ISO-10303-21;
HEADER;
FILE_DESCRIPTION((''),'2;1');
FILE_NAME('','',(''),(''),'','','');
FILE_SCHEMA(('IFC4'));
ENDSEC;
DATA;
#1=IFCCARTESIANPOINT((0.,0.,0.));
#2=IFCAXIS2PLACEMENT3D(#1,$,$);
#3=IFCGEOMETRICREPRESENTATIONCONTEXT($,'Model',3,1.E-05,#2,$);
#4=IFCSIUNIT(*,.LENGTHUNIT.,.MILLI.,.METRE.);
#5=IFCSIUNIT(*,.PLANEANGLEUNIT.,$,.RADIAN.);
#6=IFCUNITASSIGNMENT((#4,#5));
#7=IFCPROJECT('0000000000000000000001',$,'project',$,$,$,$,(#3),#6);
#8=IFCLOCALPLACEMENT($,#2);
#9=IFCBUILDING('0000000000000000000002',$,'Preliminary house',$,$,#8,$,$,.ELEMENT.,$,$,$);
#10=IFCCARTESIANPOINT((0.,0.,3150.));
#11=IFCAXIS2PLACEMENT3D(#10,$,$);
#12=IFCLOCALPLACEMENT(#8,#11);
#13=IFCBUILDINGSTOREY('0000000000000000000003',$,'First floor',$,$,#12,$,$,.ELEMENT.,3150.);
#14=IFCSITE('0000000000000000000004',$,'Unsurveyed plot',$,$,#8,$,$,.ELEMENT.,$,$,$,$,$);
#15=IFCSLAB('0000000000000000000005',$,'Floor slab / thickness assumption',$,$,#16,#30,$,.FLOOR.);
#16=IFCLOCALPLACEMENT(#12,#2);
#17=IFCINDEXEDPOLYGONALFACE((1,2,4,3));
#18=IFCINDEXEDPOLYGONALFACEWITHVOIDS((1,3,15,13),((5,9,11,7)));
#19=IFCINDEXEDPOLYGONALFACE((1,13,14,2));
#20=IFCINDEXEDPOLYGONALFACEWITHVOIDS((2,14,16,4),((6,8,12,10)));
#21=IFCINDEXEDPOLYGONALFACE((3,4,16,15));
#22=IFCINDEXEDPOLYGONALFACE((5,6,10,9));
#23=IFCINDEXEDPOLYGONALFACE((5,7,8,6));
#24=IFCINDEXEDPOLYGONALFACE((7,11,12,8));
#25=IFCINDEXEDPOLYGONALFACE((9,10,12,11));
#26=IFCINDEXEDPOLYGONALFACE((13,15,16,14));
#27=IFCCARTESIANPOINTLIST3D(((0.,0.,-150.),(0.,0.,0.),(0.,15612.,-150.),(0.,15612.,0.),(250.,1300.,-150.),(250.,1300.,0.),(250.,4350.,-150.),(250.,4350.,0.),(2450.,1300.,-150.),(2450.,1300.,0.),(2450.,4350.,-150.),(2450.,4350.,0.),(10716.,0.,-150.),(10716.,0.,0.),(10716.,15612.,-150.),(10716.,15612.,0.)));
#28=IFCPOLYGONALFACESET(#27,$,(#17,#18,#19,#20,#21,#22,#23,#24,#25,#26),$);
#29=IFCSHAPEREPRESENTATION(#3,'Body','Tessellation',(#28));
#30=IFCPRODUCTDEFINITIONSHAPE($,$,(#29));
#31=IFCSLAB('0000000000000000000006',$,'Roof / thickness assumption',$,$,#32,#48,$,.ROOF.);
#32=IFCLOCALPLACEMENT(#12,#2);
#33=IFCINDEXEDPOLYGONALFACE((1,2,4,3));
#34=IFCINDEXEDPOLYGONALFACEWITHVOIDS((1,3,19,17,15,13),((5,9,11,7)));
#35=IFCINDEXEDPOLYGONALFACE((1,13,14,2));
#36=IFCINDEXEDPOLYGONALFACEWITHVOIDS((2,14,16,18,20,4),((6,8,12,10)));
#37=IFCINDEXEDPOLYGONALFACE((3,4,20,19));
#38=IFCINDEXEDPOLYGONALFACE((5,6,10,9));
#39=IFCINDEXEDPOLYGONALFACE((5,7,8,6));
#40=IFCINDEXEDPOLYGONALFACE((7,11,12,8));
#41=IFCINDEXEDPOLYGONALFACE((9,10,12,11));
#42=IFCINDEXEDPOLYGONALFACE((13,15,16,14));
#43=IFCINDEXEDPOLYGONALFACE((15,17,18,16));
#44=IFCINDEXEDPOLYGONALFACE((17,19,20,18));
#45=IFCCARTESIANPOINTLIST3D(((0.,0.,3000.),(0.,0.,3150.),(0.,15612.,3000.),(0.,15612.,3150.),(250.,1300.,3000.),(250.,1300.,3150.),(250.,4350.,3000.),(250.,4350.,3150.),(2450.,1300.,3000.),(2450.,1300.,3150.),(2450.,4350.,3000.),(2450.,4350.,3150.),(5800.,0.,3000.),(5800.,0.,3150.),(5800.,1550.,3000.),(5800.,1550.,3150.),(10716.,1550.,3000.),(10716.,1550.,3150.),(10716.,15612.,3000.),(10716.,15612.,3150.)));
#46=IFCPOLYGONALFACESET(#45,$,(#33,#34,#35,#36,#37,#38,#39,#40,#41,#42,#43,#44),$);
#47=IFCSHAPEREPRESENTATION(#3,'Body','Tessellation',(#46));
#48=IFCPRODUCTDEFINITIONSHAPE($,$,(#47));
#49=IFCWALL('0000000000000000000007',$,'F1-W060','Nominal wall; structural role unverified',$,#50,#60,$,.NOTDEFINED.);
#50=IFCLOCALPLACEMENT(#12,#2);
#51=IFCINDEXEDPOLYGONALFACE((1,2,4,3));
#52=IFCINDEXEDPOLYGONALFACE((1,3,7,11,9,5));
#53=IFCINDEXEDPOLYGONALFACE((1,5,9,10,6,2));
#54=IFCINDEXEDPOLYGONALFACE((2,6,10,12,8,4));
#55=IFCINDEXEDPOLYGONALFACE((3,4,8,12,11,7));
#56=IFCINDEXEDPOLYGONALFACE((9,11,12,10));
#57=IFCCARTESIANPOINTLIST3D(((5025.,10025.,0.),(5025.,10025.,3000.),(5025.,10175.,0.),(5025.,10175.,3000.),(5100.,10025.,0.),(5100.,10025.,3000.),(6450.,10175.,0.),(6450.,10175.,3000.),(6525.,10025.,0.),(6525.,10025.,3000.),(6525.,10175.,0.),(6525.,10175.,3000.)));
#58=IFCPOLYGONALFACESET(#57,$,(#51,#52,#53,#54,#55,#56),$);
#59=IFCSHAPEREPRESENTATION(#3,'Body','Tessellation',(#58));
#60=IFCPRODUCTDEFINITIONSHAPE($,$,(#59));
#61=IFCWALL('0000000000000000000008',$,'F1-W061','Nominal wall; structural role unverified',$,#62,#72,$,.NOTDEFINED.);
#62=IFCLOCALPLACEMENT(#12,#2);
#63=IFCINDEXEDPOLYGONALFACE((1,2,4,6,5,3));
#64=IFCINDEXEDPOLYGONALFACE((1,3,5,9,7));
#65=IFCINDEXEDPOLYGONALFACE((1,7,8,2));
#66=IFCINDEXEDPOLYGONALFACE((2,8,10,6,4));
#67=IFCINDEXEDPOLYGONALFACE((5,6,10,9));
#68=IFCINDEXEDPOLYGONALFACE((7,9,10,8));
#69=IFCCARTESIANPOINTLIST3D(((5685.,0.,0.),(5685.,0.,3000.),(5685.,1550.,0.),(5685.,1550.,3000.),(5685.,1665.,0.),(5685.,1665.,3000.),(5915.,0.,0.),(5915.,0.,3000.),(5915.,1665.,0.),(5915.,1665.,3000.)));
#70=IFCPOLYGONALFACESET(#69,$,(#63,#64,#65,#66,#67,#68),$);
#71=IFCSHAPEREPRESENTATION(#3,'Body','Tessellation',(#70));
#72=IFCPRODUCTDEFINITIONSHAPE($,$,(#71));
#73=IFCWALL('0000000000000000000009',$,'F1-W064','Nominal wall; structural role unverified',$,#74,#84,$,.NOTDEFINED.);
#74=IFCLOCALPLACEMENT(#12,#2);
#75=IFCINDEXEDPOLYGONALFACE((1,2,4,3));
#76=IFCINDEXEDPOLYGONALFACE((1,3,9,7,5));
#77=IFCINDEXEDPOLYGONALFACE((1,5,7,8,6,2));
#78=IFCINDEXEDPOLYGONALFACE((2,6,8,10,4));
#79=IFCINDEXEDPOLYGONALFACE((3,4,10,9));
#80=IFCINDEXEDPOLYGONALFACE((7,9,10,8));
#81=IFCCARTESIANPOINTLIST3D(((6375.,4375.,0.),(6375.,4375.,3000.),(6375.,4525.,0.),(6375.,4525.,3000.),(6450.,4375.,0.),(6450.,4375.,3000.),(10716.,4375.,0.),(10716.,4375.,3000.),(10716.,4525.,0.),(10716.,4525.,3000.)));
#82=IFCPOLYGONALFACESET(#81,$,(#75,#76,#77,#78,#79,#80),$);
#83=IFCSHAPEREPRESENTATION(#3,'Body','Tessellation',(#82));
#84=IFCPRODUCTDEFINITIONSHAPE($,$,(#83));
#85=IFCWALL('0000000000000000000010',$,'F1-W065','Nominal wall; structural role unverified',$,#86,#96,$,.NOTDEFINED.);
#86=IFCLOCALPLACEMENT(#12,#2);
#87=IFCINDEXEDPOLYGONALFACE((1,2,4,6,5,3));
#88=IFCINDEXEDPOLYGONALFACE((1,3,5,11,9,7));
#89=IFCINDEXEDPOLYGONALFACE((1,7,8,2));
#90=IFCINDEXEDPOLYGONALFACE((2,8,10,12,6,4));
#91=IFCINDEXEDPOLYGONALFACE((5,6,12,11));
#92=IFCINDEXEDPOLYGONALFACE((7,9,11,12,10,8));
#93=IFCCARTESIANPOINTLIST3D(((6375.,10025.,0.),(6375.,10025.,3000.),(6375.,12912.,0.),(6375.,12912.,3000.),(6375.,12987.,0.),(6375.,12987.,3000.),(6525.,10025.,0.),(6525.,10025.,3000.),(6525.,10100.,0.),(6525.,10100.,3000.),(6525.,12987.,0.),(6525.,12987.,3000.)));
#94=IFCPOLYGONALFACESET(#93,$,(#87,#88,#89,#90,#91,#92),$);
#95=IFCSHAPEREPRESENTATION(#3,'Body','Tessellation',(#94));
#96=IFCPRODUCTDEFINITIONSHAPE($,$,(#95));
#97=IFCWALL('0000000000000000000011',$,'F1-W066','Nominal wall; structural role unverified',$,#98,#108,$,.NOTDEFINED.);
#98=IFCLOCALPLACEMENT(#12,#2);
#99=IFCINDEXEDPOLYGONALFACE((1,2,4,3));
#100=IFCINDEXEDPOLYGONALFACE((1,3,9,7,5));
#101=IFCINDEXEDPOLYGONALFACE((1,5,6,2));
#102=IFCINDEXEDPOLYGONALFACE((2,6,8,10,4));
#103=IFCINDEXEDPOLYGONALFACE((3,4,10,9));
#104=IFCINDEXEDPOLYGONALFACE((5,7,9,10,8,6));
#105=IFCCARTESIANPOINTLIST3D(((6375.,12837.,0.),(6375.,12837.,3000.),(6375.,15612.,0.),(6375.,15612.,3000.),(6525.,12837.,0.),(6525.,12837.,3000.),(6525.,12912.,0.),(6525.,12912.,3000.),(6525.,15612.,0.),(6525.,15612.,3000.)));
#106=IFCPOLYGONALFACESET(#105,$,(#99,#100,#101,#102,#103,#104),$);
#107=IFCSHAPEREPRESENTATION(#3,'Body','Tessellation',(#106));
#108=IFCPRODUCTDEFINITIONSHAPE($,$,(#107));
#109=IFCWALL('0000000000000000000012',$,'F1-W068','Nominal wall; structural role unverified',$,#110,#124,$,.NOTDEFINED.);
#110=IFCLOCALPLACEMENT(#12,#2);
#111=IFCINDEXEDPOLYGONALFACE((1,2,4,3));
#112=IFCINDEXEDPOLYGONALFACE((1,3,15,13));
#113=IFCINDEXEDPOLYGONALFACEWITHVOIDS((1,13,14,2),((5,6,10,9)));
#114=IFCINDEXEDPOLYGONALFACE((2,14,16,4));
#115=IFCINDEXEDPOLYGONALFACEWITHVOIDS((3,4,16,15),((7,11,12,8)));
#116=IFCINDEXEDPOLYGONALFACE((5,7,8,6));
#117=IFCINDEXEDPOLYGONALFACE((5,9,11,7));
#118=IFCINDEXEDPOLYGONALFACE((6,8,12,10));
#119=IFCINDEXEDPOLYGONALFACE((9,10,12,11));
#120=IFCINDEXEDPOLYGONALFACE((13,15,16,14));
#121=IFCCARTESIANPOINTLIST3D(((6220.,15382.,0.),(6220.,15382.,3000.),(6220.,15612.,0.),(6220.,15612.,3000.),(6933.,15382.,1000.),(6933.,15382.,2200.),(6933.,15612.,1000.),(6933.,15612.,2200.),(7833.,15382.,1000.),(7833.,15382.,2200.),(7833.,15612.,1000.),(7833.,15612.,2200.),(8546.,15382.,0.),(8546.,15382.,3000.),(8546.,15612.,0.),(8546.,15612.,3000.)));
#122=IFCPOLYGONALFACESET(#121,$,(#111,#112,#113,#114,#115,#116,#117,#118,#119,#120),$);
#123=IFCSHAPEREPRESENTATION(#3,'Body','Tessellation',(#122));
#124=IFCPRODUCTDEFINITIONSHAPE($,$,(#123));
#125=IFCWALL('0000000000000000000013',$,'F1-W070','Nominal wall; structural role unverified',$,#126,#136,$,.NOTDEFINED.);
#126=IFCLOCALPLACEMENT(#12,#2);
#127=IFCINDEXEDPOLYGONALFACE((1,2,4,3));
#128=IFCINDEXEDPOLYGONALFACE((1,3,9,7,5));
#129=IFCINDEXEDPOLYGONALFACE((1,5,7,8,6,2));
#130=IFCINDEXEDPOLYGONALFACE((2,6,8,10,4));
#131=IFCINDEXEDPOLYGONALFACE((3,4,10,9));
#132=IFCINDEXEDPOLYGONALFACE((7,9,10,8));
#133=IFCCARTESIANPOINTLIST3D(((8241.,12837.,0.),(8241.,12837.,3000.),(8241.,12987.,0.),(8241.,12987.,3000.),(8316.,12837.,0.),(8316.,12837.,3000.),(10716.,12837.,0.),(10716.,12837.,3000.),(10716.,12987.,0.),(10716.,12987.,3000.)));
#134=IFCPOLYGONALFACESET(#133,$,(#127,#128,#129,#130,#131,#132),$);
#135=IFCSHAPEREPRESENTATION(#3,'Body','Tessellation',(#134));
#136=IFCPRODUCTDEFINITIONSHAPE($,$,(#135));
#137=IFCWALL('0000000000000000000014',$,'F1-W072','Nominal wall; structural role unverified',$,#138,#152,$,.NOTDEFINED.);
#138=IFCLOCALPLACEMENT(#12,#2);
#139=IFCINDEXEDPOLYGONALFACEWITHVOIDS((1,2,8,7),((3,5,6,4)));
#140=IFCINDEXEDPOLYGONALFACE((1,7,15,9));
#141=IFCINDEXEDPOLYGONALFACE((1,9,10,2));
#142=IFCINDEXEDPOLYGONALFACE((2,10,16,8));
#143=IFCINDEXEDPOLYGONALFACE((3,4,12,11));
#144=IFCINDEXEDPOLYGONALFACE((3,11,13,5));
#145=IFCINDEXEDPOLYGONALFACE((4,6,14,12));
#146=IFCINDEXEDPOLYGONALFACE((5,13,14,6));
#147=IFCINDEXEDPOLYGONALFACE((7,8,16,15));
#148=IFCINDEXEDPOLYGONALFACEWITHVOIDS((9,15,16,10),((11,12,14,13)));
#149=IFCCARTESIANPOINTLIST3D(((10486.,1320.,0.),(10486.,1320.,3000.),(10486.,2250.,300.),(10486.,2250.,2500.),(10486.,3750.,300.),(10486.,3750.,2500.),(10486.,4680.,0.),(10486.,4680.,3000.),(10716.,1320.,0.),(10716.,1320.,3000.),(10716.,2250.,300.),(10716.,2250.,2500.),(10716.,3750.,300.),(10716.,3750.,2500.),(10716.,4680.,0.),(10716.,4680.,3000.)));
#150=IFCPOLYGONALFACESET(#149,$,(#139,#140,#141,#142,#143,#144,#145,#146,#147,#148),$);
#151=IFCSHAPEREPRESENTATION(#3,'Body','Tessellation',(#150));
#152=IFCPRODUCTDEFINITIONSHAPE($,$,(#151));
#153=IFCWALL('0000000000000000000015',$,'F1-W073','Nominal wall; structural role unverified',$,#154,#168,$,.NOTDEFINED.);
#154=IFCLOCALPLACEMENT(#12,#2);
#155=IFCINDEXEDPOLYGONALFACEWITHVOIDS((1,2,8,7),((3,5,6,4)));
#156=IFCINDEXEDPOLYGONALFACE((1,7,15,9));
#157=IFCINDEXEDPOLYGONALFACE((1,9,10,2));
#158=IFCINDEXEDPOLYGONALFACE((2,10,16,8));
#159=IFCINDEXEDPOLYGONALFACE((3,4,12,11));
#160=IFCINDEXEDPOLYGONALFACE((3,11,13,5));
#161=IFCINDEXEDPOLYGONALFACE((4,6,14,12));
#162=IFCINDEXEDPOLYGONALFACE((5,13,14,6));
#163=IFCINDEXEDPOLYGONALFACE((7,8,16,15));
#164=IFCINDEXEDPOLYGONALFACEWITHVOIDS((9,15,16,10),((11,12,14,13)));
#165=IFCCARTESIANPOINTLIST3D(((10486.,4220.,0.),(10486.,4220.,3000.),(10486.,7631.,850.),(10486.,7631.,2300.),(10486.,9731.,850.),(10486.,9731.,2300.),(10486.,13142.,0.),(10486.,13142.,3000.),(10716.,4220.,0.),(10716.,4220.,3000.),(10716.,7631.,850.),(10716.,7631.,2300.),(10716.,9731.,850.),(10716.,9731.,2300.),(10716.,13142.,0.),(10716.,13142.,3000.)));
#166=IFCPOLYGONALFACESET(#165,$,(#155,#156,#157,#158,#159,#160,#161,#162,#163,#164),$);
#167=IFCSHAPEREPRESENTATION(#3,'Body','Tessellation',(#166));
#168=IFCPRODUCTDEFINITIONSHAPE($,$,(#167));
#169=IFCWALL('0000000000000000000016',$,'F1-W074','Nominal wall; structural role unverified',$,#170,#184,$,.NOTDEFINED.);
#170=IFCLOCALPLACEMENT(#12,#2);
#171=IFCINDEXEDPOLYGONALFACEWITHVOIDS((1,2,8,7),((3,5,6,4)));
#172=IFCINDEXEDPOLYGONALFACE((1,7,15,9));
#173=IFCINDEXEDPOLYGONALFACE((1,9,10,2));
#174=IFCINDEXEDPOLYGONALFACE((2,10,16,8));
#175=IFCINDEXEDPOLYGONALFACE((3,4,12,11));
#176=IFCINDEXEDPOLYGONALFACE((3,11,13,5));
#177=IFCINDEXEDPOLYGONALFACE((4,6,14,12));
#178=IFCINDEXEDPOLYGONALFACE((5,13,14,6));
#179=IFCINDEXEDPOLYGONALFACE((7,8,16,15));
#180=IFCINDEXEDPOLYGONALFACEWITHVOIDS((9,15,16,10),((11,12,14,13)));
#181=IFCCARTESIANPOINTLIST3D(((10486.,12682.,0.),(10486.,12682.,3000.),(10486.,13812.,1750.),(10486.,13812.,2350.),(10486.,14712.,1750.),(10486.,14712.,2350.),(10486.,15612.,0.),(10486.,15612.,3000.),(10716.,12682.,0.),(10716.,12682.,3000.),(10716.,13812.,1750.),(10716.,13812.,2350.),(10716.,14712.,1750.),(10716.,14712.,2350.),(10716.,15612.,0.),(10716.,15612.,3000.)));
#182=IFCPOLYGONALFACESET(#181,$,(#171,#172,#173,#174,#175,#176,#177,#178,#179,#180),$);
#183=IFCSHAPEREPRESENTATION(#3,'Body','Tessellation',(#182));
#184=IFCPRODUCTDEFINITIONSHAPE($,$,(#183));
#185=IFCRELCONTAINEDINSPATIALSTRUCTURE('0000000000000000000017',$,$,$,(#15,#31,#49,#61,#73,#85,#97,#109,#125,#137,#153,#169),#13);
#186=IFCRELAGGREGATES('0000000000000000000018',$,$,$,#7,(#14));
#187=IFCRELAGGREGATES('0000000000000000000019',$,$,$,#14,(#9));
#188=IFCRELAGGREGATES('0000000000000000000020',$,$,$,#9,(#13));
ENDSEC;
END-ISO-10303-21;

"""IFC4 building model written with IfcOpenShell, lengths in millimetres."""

from ifc_helpers import new_model, si_unit, frame, origin, place, context, project, spatial, polyline, outline, extrude, element, save


model = new_model("IFC4")

# Units and contexts
model_context = context("Model", 3, precision=1e-05, world=origin())
ifc_project = project(units=[si_unit("LENGTHUNIT", "METRE", prefix="MILLI"), si_unit("PLANEANGLEUNIT", "RADIAN")], contexts=[model_context])

# Site, building, storey
placement_1 = place(None, origin())
site = spatial("IfcSite", under=ifc_project, at=placement_1, Name="Unsurveyed plot", CompositionType="ELEMENT")
building = spatial("IfcBuilding", under=site, at=placement_1, Name="Preliminary house", CompositionType="ELEMENT")
placement_2 = place(placement_1, frame((0.0, 0.0, 3150.0)))
storey = spatial("IfcBuildingStorey", under=building, at=placement_2, Name="First floor", CompositionType="ELEMENT", Elevation=3150.0)

# Slabs
element("IfcSlab", 1, at=placement_2, inside=storey, Name="Floor slab / thickness assumption", PredefinedType="FLOOR", context=model_context, shape_type="SweptSolid", body=[
    extrude(outline(polyline([(0.0, 0.0), (0.0, 15612.0), (10716.0, 15612.0), (10716.0, 0.0), (0.0, 0.0)]), holes=[polyline([(2450.0, 4350.0), (250.0, 4350.0), (250.0, 1300.0), (2450.0, 1300.0), (2450.0, 4350.0)])]), frame((0.0, 0.0, -150.0)), (0.0, 0.0, 1.0), 150.0),
])
element("IfcSlab", 2, at=placement_2, inside=storey, Name="Roof / thickness assumption", PredefinedType="ROOF", context=model_context, shape_type="SweptSolid", body=[
    extrude(outline(polyline([(0.0, 15612.0), (10716.0, 15612.0), (10716.0, 1550.0), (5800.0, 1550.0), (5800.0, 0.0), (0.0, 0.0), (0.0, 15612.0)]), holes=[polyline([(2450.0, 4350.0), (250.0, 4350.0), (250.0, 1300.0), (2450.0, 1300.0), (2450.0, 4350.0)])]), frame((0.0, 0.0, 3000.0)), (0.0, 0.0, 1.0), 150.0),
])

# Walls
element("IfcWall", 3, at=placement_2, inside=storey, Name="F1-W060", Description="Nominal wall; structural role unverified", PredefinedType="NOTDEFINED", context=model_context, shape_type="SweptSolid", body=[
    extrude(outline(polyline([(6525.0, 10175.0), (6525.0, 10025.0), (5100.0, 10025.0), (5025.0, 10025.0), (5025.0, 10175.0), (6450.0, 10175.0), (6525.0, 10175.0)])), origin(), (0.0, 0.0, 1.0), 3000.0),
])
element("IfcWall", 4, at=placement_2, inside=storey, Name="F1-W061", Description="Nominal wall; structural role unverified", PredefinedType="NOTDEFINED", context=model_context, shape_type="SweptSolid", body=[
    extrude(outline(polyline([(5685.0, 1665.0), (5915.0, 1665.0), (5915.0, 0.0), (5685.0, 0.0), (5685.0, 1550.0), (5685.0, 1665.0)])), origin(), (0.0, 0.0, 1.0), 3000.0),
])

# Walls
element("IfcWall", 5, at=placement_2, inside=storey, Name="F1-W064", Description="Nominal wall; structural role unverified", PredefinedType="NOTDEFINED", context=model_context, shape_type="SweptSolid", body=[
    extrude(outline(polyline([(6450.0, 4375.0), (6375.0, 4375.0), (6375.0, 4525.0), (10716.0, 4525.0), (10716.0, 4375.0), (6450.0, 4375.0)])), origin(), (0.0, 0.0, 1.0), 3000.0),
])
element("IfcWall", 6, at=placement_2, inside=storey, Name="F1-W065", Description="Nominal wall; structural role unverified", PredefinedType="NOTDEFINED", context=model_context, shape_type="SweptSolid", body=[
    extrude(outline(polyline([(6375.0, 12987.0), (6525.0, 12987.0), (6525.0, 10100.0), (6525.0, 10025.0), (6375.0, 10025.0), (6375.0, 12912.0), (6375.0, 12987.0)])), origin(), (0.0, 0.0, 1.0), 3000.0),
])
element("IfcWall", 7, at=placement_2, inside=storey, Name="F1-W066", Description="Nominal wall; structural role unverified", PredefinedType="NOTDEFINED", context=model_context, shape_type="SweptSolid", body=[
    extrude(outline(polyline([(6525.0, 12912.0), (6525.0, 12837.0), (6375.0, 12837.0), (6375.0, 15612.0), (6525.0, 15612.0), (6525.0, 12912.0)])), origin(), (0.0, 0.0, 1.0), 3000.0),
])

# Wall, opening
wall_1 = element("IfcWall", 8, at=placement_2, inside=storey, Name="F1-W068", Description="Nominal wall; structural role unverified", PredefinedType="NOTDEFINED", context=model_context, shape_type="SweptSolid", body=[
    extrude(outline(polyline([(8546.0, 15382.0), (6450.0, 15382.0), (6220.0, 15382.0), (6220.0, 15612.0), (8546.0, 15612.0), (8546.0, 15382.0)])), origin(), (0.0, 0.0, 1.0), 3000.0),
])
element("IfcOpeningElement", 9, at=placement_2, cuts=wall_1, PredefinedType="OPENING", context=model_context, shape_type="SweptSolid", body=[
    extrude(outline(polyline([(6933.0, 14967.0), (7833.0, 14967.0), (7833.0, 16027.0), (6933.0, 16027.0), (6933.0, 14967.0)])), frame((0.0, 0.0, 1000.0)), (0.0, 0.0, 1.0), 1200.0),
])

# Wall
element("IfcWall", 10, at=placement_2, inside=storey, Name="F1-W070", Description="Nominal wall; structural role unverified", PredefinedType="NOTDEFINED", context=model_context, shape_type="SweptSolid", body=[
    extrude(outline(polyline([(8316.0, 12837.0), (8241.0, 12837.0), (8241.0, 12987.0), (10716.0, 12987.0), (10716.0, 12837.0), (8316.0, 12837.0)])), origin(), (0.0, 0.0, 1.0), 3000.0),
])

# Walls, openings
wall_2 = element("IfcWall", 11, at=placement_2, inside=storey, Name="F1-W072", Description="Nominal wall; structural role unverified", PredefinedType="NOTDEFINED", context=model_context, shape_type="SweptSolid", body=[
    extrude(outline(polyline([(10486.0, 4680.0), (10716.0, 4680.0), (10716.0, 1320.0), (10486.0, 1320.0), (10486.0, 4450.0), (10486.0, 4680.0)])), origin(), (0.0, 0.0, 1.0), 3000.0),
])
element("IfcOpeningElement", 12, at=placement_2, cuts=wall_2, PredefinedType="OPENING", context=model_context, shape_type="SweptSolid", body=[
    extrude(outline(polyline([(11131.0, 2250.0), (11131.0, 3750.0), (10071.0, 3750.0), (10071.0, 2250.0), (11131.0, 2250.0)])), frame((0.0, 0.0, 300.0)), (0.0, 0.0, 1.0), 2200.0),
])
wall_3 = element("IfcWall", 13, at=placement_2, inside=storey, Name="F1-W073", Description="Nominal wall; structural role unverified", PredefinedType="NOTDEFINED", context=model_context, shape_type="SweptSolid", body=[
    extrude(outline(polyline([(10486.0, 13142.0), (10716.0, 13142.0), (10716.0, 4220.0), (10486.0, 4220.0), (10486.0, 12912.0), (10486.0, 13142.0)])), origin(), (0.0, 0.0, 1.0), 3000.0),
])
element("IfcOpeningElement", 14, at=placement_2, cuts=wall_3, PredefinedType="OPENING", context=model_context, shape_type="SweptSolid", body=[
    extrude(outline(polyline([(11131.0, 7631.0), (11131.0, 9731.0), (10071.0, 9731.0), (10071.0, 7631.0), (11131.0, 7631.0)])), frame((0.0, 0.0, 850.0)), (0.0, 0.0, 1.0), 1450.0),
])
wall_4 = element("IfcWall", 15, at=placement_2, inside=storey, Name="F1-W074", Description="Nominal wall; structural role unverified", PredefinedType="NOTDEFINED", context=model_context, shape_type="SweptSolid", body=[
    extrude(outline(polyline([(10486.0, 12682.0), (10486.0, 15612.0), (10716.0, 15612.0), (10716.0, 12682.0), (10486.0, 12682.0)])), origin(), (0.0, 0.0, 1.0), 3000.0),
])
element("IfcOpeningElement", 16, at=placement_2, cuts=wall_4, PredefinedType="OPENING", context=model_context, shape_type="SweptSolid", body=[
    extrude(outline(polyline([(11131.0, 13812.0), (11131.0, 14712.0), (10071.0, 14712.0), (10071.0, 13812.0), (11131.0, 13812.0)])), frame((0.0, 0.0, 1750.0)), (0.0, 0.0, 1.0), 600.0),
])

save(model, "model.ifc")
